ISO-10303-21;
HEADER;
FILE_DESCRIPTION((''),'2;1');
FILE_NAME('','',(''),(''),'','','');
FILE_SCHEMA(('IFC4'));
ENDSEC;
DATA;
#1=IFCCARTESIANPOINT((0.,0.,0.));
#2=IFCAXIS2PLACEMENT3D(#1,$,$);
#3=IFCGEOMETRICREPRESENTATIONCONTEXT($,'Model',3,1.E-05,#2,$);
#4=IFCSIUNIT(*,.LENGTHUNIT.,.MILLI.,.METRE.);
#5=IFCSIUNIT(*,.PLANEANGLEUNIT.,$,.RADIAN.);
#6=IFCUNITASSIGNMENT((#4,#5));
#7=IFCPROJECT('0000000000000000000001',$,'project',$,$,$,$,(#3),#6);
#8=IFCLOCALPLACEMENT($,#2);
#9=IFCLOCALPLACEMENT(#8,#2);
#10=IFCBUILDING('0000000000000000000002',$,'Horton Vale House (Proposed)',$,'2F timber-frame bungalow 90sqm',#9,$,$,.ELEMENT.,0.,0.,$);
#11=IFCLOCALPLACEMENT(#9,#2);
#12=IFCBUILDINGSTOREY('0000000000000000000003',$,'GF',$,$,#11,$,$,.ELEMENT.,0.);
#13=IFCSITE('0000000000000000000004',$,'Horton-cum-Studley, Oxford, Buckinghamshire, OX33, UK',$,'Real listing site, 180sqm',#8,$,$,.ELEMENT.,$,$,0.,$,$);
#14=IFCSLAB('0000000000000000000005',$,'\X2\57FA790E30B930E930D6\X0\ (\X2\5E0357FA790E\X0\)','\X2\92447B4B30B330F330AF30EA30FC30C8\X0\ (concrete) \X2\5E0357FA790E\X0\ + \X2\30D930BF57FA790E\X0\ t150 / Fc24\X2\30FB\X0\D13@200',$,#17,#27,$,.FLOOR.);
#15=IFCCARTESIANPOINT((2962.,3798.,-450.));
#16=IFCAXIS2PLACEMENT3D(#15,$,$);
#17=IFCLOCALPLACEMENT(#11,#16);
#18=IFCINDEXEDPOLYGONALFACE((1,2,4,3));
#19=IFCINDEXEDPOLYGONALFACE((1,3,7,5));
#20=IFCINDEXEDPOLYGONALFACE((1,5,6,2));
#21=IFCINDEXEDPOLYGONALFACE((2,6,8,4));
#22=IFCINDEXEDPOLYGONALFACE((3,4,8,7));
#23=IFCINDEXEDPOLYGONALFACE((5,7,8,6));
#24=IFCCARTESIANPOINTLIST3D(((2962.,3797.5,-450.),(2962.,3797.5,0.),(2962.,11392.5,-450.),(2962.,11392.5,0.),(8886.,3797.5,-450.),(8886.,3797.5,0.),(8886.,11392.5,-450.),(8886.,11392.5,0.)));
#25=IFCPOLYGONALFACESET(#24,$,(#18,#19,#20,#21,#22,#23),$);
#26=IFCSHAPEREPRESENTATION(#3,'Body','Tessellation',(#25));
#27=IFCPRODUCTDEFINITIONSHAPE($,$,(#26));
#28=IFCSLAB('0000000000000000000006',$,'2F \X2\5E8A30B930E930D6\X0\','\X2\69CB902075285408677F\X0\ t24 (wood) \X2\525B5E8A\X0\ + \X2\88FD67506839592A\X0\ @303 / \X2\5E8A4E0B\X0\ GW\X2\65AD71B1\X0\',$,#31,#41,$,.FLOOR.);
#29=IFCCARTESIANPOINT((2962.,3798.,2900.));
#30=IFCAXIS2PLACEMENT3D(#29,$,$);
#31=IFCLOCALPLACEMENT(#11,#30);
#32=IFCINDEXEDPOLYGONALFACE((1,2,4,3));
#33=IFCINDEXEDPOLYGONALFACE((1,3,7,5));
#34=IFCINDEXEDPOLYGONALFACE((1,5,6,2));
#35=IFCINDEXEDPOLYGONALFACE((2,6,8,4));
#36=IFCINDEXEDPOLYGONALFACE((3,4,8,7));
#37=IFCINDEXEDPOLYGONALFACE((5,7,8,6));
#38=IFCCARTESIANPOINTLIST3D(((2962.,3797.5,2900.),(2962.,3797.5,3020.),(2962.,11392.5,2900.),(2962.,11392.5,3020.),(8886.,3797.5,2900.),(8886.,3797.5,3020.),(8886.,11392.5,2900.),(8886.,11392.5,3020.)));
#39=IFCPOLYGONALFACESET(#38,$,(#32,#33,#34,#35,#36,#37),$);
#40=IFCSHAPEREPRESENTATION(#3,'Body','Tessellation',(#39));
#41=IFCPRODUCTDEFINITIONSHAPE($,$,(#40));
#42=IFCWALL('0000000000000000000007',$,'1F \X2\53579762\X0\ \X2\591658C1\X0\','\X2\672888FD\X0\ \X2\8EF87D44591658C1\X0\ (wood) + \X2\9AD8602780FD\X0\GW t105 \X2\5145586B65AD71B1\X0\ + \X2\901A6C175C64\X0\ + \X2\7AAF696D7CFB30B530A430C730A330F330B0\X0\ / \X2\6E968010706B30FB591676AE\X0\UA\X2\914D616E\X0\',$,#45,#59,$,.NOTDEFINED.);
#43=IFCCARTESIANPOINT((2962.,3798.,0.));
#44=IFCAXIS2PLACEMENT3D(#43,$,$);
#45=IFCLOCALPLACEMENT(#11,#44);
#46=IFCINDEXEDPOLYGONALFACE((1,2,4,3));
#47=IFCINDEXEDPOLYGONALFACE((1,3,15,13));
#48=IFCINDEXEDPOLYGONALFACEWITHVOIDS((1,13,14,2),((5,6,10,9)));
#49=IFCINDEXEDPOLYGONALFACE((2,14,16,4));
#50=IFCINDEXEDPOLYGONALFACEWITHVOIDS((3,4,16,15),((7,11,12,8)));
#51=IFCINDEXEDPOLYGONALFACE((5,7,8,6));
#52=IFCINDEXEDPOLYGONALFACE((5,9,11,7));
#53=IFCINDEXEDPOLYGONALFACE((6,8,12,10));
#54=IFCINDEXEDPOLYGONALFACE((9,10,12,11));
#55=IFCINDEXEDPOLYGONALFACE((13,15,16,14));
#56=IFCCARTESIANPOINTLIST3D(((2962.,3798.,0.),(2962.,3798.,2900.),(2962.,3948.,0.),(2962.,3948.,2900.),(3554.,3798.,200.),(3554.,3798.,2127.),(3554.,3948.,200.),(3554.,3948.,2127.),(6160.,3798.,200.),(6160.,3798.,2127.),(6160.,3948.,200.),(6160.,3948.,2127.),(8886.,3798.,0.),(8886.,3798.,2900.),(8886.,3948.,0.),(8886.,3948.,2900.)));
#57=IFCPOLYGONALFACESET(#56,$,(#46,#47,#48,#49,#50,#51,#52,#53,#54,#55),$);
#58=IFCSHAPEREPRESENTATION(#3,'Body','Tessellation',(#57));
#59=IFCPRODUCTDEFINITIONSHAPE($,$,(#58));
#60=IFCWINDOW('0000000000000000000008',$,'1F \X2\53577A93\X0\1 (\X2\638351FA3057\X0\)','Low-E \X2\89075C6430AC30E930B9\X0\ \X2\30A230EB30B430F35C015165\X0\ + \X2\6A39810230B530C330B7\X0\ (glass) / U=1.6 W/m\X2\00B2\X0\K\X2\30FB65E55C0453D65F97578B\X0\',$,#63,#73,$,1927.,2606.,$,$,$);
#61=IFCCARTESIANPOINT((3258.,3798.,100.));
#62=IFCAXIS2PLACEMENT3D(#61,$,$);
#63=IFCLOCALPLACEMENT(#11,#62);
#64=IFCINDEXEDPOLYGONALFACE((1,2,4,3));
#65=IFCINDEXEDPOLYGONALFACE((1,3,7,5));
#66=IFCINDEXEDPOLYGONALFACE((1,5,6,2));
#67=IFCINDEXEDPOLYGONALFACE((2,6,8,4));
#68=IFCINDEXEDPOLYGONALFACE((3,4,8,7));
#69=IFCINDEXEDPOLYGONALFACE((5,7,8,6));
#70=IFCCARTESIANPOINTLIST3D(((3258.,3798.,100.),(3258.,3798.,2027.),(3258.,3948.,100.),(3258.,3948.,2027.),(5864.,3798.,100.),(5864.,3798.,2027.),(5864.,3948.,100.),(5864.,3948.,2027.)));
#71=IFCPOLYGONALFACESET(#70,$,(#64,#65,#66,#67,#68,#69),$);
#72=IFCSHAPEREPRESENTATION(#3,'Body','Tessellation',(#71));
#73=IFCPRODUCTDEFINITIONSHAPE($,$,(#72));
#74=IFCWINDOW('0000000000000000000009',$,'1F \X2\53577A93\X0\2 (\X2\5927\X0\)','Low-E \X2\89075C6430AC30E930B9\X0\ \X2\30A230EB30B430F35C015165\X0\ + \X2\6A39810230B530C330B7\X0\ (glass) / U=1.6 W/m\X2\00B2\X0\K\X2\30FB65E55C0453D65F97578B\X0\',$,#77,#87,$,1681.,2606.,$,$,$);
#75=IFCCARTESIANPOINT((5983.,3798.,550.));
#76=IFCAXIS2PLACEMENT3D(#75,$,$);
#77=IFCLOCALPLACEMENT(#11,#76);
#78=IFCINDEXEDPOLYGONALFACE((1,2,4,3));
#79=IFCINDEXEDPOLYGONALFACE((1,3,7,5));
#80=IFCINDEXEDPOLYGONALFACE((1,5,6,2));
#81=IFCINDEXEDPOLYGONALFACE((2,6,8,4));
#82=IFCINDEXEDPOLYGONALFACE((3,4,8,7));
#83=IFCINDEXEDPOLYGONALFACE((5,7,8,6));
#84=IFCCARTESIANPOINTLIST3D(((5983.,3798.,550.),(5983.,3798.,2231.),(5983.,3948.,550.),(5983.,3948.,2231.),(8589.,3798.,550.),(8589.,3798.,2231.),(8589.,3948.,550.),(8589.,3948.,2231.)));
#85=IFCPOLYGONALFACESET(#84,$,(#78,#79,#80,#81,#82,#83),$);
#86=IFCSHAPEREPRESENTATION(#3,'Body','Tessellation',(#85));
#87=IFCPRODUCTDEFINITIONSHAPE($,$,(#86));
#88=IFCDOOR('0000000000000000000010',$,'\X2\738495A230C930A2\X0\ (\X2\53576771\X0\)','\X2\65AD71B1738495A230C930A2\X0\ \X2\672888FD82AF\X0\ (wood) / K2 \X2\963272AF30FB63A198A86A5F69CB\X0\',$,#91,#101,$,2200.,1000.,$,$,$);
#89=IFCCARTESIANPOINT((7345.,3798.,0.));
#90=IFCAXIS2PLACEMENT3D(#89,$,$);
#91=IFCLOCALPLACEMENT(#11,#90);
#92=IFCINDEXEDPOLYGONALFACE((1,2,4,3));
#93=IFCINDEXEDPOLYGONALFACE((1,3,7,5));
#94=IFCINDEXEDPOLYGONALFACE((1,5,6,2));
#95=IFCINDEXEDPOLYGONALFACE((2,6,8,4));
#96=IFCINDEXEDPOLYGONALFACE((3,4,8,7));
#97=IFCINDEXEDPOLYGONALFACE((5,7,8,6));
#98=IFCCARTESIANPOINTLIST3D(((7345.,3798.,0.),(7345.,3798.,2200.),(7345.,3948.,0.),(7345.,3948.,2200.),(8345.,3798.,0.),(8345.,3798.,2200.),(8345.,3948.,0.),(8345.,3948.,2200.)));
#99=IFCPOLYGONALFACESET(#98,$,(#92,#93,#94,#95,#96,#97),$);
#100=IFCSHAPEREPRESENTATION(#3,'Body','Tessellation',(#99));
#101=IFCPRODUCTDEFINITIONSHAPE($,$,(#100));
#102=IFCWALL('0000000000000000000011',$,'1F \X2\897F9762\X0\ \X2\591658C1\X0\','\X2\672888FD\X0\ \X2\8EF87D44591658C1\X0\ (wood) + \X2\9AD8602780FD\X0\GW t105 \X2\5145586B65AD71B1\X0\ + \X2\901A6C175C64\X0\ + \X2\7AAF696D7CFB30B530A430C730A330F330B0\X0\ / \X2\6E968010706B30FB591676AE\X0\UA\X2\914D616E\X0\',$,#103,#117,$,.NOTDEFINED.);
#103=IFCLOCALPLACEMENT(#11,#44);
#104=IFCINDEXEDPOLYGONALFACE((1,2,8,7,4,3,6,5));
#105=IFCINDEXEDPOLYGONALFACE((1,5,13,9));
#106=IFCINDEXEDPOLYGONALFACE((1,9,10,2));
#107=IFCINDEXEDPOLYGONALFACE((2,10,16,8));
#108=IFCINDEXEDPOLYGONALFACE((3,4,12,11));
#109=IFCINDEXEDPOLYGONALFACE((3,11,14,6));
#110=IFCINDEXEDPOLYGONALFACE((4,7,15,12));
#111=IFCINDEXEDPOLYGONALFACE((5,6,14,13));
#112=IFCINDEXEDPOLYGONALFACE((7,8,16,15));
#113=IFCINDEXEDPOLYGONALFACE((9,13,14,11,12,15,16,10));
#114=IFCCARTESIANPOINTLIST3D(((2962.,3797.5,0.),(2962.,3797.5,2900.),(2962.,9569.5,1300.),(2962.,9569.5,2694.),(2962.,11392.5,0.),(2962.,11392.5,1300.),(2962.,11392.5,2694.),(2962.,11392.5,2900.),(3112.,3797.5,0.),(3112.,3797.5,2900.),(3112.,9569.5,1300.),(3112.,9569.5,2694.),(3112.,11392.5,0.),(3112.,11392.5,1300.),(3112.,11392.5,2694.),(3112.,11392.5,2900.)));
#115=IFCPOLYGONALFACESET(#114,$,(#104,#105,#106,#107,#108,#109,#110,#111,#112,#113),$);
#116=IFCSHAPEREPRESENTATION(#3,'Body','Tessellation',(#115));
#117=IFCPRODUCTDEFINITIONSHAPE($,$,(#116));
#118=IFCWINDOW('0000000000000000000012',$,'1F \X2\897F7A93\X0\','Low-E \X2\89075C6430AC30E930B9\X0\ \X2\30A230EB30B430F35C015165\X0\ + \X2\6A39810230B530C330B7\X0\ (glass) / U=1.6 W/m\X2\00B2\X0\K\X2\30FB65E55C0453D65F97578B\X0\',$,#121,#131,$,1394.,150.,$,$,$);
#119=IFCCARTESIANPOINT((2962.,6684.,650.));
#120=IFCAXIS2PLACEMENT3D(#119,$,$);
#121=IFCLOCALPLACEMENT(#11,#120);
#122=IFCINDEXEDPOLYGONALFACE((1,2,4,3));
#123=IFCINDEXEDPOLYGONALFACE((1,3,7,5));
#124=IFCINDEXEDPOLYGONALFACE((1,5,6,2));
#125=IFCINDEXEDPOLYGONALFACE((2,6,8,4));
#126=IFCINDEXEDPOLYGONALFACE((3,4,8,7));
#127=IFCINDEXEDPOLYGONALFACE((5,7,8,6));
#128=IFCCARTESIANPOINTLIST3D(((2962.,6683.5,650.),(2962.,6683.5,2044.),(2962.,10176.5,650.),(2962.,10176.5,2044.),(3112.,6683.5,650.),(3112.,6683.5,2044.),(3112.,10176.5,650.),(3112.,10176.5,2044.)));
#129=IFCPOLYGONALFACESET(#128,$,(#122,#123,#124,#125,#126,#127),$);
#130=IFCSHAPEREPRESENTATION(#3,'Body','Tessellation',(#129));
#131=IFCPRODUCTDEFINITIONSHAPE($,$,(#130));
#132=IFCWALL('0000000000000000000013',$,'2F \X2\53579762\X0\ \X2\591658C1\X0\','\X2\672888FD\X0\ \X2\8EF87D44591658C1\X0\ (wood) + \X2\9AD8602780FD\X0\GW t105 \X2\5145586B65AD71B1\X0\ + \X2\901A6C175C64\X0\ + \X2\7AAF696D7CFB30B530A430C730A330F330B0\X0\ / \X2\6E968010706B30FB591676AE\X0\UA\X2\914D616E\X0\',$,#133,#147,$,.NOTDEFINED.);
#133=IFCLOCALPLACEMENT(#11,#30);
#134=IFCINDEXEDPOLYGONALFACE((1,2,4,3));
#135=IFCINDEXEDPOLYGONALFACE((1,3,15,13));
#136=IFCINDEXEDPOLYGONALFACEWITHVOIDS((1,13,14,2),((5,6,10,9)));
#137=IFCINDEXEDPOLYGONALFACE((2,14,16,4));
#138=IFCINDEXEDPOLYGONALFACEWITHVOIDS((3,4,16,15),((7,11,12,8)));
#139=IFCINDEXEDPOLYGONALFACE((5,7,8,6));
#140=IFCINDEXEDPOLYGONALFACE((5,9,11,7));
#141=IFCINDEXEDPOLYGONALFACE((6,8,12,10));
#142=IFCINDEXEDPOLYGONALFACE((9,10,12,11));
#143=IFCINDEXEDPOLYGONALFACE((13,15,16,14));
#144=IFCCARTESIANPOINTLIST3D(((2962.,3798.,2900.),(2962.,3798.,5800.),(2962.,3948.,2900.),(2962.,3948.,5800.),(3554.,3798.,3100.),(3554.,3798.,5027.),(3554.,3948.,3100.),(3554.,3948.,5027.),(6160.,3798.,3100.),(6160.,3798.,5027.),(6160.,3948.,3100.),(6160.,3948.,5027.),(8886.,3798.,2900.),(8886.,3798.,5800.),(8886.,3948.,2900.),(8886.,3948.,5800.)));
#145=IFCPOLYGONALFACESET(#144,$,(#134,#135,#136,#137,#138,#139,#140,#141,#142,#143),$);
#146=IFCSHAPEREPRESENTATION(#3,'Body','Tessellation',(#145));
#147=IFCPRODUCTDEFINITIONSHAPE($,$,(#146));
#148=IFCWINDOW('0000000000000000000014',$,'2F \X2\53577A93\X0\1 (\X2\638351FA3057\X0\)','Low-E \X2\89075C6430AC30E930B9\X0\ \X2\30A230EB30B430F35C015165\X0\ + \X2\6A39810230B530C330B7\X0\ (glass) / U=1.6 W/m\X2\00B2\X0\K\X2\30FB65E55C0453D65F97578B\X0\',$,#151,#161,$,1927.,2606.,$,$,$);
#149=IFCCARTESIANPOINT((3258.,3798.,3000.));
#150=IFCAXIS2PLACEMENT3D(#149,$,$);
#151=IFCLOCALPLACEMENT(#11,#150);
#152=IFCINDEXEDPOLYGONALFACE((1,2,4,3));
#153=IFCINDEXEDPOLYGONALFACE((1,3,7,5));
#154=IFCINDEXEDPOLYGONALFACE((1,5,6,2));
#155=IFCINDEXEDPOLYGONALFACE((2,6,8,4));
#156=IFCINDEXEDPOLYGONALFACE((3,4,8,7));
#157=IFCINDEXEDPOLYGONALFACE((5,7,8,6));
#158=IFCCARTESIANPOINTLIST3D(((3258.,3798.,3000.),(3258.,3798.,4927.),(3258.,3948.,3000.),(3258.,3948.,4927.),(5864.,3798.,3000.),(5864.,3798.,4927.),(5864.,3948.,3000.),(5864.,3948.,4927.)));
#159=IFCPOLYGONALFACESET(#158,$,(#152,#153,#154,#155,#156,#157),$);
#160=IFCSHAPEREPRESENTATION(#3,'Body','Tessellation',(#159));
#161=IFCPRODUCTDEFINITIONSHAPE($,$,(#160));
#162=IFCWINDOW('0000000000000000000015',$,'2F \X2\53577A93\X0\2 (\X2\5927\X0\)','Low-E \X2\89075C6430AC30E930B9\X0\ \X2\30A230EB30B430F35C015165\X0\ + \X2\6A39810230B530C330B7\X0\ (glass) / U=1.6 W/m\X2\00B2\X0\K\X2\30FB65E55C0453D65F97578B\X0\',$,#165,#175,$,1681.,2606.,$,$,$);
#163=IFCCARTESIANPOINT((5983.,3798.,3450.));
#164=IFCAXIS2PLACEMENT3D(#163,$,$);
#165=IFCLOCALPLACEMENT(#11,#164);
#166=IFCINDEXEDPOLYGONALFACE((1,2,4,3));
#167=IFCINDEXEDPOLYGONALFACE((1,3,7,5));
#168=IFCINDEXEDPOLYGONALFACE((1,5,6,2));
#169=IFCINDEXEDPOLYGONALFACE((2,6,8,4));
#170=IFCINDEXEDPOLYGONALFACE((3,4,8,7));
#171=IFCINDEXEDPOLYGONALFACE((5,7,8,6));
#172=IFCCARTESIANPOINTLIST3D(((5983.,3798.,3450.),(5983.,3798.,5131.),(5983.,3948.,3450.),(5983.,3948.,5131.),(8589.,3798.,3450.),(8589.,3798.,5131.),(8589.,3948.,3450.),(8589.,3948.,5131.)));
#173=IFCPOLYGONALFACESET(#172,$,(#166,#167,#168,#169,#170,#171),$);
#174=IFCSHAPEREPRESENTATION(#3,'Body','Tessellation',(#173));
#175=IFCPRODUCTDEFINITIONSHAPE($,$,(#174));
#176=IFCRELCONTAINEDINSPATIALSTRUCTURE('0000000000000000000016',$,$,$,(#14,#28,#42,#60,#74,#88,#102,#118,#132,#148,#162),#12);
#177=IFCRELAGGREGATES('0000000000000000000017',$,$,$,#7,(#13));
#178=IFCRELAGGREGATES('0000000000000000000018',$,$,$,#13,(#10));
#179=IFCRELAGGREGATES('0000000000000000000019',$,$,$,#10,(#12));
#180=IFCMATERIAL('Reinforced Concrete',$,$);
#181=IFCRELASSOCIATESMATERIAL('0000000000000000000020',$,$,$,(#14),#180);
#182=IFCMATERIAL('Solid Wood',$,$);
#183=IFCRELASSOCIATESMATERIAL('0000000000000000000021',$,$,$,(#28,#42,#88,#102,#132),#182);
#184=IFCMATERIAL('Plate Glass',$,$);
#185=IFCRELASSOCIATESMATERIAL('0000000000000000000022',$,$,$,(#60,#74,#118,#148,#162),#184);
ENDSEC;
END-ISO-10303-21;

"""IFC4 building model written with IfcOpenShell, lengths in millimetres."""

from ifc_helpers import new_model, si_unit, frame, frame_2d, origin, place, context, project, spatial, rectangle, extrude, material, element, fill, save


model = new_model("IFC4")

# Units and contexts
model_context = context("Model", 3, precision=1e-05, world=origin())
ifc_project = project(units=[si_unit("LENGTHUNIT", "METRE", prefix="MILLI"), si_unit("PLANEANGLEUNIT", "RADIAN")], contexts=[model_context])

# Site, building, storey
site_placement = place(None, origin())
site = spatial("IfcSite", under=ifc_project, at=site_placement, Name="Horton-cum-Studley, Oxford, Buckinghamshire, OX33, UK", ObjectType="Real listing site, 180sqm", CompositionType="ELEMENT", RefElevation=0.0)
building_placement = place(site_placement, origin())
building = spatial("IfcBuilding", under=site, at=building_placement, Name="Horton Vale House (Proposed)", ObjectType="2F timber-frame bungalow 90sqm", CompositionType="ELEMENT", ElevationOfRefHeight=0.0, ElevationOfTerrain=0.0)
storey_placement = place(building_placement, origin())
storey = spatial("IfcBuildingStorey", under=building, at=storey_placement, Name="GF", CompositionType="ELEMENT", Elevation=0.0)

# Slabs
ifc_material_1 = material(Name="Reinforced Concrete")
slab_1_placement = place(storey_placement, frame((2962.0, 3798.0, -450.0)))
element("IfcSlab", 1, at=slab_1_placement, inside=storey, material=ifc_material_1, Name="基礎スラブ (布基礎)", Description="鉄筋コンクリート (concrete) 布基礎 + ベタ基礎 t150 / Fc24・D13@200", PredefinedType="FLOOR", context=model_context, shape_type="SweptSolid", body=[
    extrude(rectangle(XDim=5924.0, YDim=7595.0, at=frame_2d((2962.0, 3797.0))), frame((2962.0, 3798.0, -450.0)), (0.0, 0.0, 1.0), 450.0),
])
ifc_material_2 = material(Name="Solid Wood")
slab_2_placement = place(storey_placement, frame((2962.0, 3798.0, 2900.0)))
element("IfcSlab", 2, at=slab_2_placement, inside=storey, material=ifc_material_2, Name="2F 床スラブ", Description="構造用合板 t24 (wood) 剛床 + 製材根太 @303 / 床下 GW断熱", PredefinedType="FLOOR", context=model_context, shape_type="SweptSolid", body=[
    extrude(rectangle(XDim=5924.0, YDim=7595.0, at=frame_2d((2962.0, 3797.0))), frame((2962.0, 3798.0, 2900.0)), (0.0, 0.0, 1.0), 120.0),
])

# Wall, openings, windows, door
wall_1_placement = place(storey_placement, frame((2962.0, 3798.0, 0.0)))
wall_1 = element("IfcWall", 3, at=wall_1_placement, inside=storey, material=ifc_material_2, Name="1F 南面 外壁", Description="木製 軸組外壁 (wood) + 高性能GW t105 充填断熱 + 通気層 + 窯業系サイディング / 準耐火・外皮UA配慮", PredefinedType="NOTDEFINED", context=model_context, shape_type="SweptSolid", body=[
    extrude(rectangle(XDim=5924.0, YDim=150.0, at=frame_2d((2962.0, 75.0))), frame((2962.0, 3798.0, 0.0)), (0.0, 0.0, 1.0), 2900.0),
])
opening_1_placement = place(storey_placement, frame((3258.0, 3798.0, 100.0)))
opening_1 = element("IfcOpeningElement", 4, at=opening_1_placement, cuts=wall_1, PredefinedType="NOTDEFINED", context=model_context, shape_type="SweptSolid", body=[
    extrude(rectangle(XDim=2606.0, YDim=150.0, at=frame_2d((1303.0, 75.0))), frame((3258.0, 3798.0, 100.0)), (0.0, 0.0, 1.0), 1927.0),
])
opening_2_placement = place(storey_placement, frame((5983.0, 3798.0, 550.0)))
opening_2 = element("IfcOpeningElement", 5, at=opening_2_placement, cuts=wall_1, PredefinedType="NOTDEFINED", context=model_context, shape_type="SweptSolid", body=[
    extrude(rectangle(XDim=2606.0, YDim=150.0, at=frame_2d((1303.0, 75.0))), frame((5983.0, 3798.0, 550.0)), (0.0, 0.0, 1.0), 1681.0),
])
opening_3_placement = place(storey_placement, frame((7345.0, 3798.0, 0.0)))
opening_3 = element("IfcOpeningElement", 6, at=opening_3_placement, cuts=wall_1, PredefinedType="NOTDEFINED", context=model_context, shape_type="SweptSolid", body=[
    extrude(rectangle(XDim=1000.0, YDim=150.0, at=frame_2d((500.0, 75.0))), frame((7345.0, 3798.0, 0.0)), (0.0, 0.0, 1.0), 2200.0),
])
ifc_material_3 = material(Name="Plate Glass")
window_1_placement = place(storey_placement, frame((3258.0, 3798.0, 100.0)))
window_1 = element("IfcWindow", 7, at=window_1_placement, inside=storey, material=ifc_material_3, Name="1F 南窓1 (掃出し)", Description="Low-E 複層ガラス アルゴン封入 + 樹脂サッシ (glass) / U=1.6 W/m²K・日射取得型", OverallHeight=1927.0, OverallWidth=2606.0, context=model_context, shape_type="SweptSolid", body=[
    extrude(rectangle(XDim=2606.0, YDim=150.0, at=frame_2d((1303.0, 75.0))), frame((3258.0, 3798.0, 100.0)), (0.0, 0.0, 1.0), 1927.0),
])
fill(opening_1, window_1)
window_2_placement = place(storey_placement, frame((5983.0, 3798.0, 550.0)))
window_2 = element("IfcWindow", 8, at=window_2_placement, inside=storey, material=ifc_material_3, Name="1F 南窓2 (大)", Description="Low-E 複層ガラス アルゴン封入 + 樹脂サッシ (glass) / U=1.6 W/m²K・日射取得型", OverallHeight=1681.0, OverallWidth=2606.0, context=model_context, shape_type="SweptSolid", body=[
    extrude(rectangle(XDim=2606.0, YDim=150.0, at=frame_2d((1303.0, 75.0))), frame((5983.0, 3798.0, 550.0)), (0.0, 0.0, 1.0), 1681.0),
])
fill(opening_2, window_2)
door_placement = place(storey_placement, frame((7345.0, 3798.0, 0.0)))
door = element("IfcDoor", 9, at=door_placement, inside=storey, material=ifc_material_2, Name="玄関ドア (南東)", Description="断熱玄関ドア 木製芯 (wood) / K2 防犯・採風機構", OverallHeight=2200.0, OverallWidth=1000.0, context=model_context, shape_type="SweptSolid", body=[
    extrude(rectangle(XDim=1000.0, YDim=150.0, at=frame_2d((500.0, 75.0))), frame((7345.0, 3798.0, 0.0)), (0.0, 0.0, 1.0), 2200.0),
])
fill(opening_3, door)

# Wall, opening, window
wall_2_placement = place(storey_placement, frame((2962.0, 3798.0, 0.0)))
wall_2 = element("IfcWall", 10, at=wall_2_placement, inside=storey, material=ifc_material_2, Name="1F 西面 外壁", Description="木製 軸組外壁 (wood) + 高性能GW t105 充填断熱 + 通気層 + 窯業系サイディング / 準耐火・外皮UA配慮", PredefinedType="NOTDEFINED", context=model_context, shape_type="SweptSolid", body=[
    extrude(rectangle(XDim=150.0, YDim=7595.0, at=frame_2d((75.0, 3797.0))), frame((2962.0, 3798.0, 0.0)), (0.0, 0.0, 1.0), 2900.0),
])
opening_4_placement = place(storey_placement, frame((2962.0, 6684.0, 650.0)))
opening_4 = element("IfcOpeningElement", 11, at=opening_4_placement, cuts=wall_2, PredefinedType="NOTDEFINED", context=model_context, shape_type="SweptSolid", body=[
    extrude(rectangle(XDim=150.0, YDim=3493.0, at=frame_2d((75.0, 1746.0))), frame((2962.0, 6684.0, 650.0)), (0.0, 0.0, 1.0), 1394.0),
])
window_3_placement = place(storey_placement, frame((2962.0, 6684.0, 650.0)))
window_3 = element("IfcWindow", 12, at=window_3_placement, inside=storey, material=ifc_material_3, Name="1F 西窓", Description="Low-E 複層ガラス アルゴン封入 + 樹脂サッシ (glass) / U=1.6 W/m²K・日射取得型", OverallHeight=1394.0, OverallWidth=150.0, context=model_context, shape_type="SweptSolid", body=[
    extrude(rectangle(XDim=150.0, YDim=3493.0, at=frame_2d((75.0, 1746.0))), frame((2962.0, 6684.0, 650.0)), (0.0, 0.0, 1.0), 1394.0),
])
fill(opening_4, window_3)

# Wall, openings, windows
wall_3_placement = place(storey_placement, frame((2962.0, 3798.0, 2900.0)))
wall_3 = element("IfcWall", 13, at=wall_3_placement, inside=storey, material=ifc_material_2, Name="2F 南面 外壁", Description="木製 軸組外壁 (wood) + 高性能GW t105 充填断熱 + 通気層 + 窯業系サイディング / 準耐火・外皮UA配慮", PredefinedType="NOTDEFINED", context=model_context, shape_type="SweptSolid", body=[
    extrude(rectangle(XDim=5924.0, YDim=150.0, at=frame_2d((2962.0, 75.0))), frame((2962.0, 3798.0, 2900.0)), (0.0, 0.0, 1.0), 2900.0),
])
opening_5_placement = place(storey_placement, frame((3258.0, 3798.0, 3000.0)))
opening_5 = element("IfcOpeningElement", 14, at=opening_5_placement, cuts=wall_3, PredefinedType="NOTDEFINED", context=model_context, shape_type="SweptSolid", body=[
    extrude(rectangle(XDim=2606.0, YDim=150.0, at=frame_2d((1303.0, 75.0))), frame((3258.0, 3798.0, 3000.0)), (0.0, 0.0, 1.0), 1927.0),
])
opening_6_placement = place(storey_placement, frame((5983.0, 3798.0, 3450.0)))
opening_6 = element("IfcOpeningElement", 15, at=opening_6_placement, cuts=wall_3, PredefinedType="NOTDEFINED", context=model_context, shape_type="SweptSolid", body=[
    extrude(rectangle(XDim=2606.0, YDim=150.0, at=frame_2d((1303.0, 75.0))), frame((5983.0, 3798.0, 3450.0)), (0.0, 0.0, 1.0), 1681.0),
])
window_4_placement = place(storey_placement, frame((3258.0, 3798.0, 3000.0)))
window_4 = element("IfcWindow", 16, at=window_4_placement, inside=storey, material=ifc_material_3, Name="2F 南窓1 (掃出し)", Description="Low-E 複層ガラス アルゴン封入 + 樹脂サッシ (glass) / U=1.6 W/m²K・日射取得型", OverallHeight=1927.0, OverallWidth=2606.0, context=model_context, shape_type="SweptSolid", body=[
    extrude(rectangle(XDim=2606.0, YDim=150.0, at=frame_2d((1303.0, 75.0))), frame((3258.0, 3798.0, 3000.0)), (0.0, 0.0, 1.0), 1927.0),
])
fill(opening_5, window_4)
window_5_placement = place(storey_placement, frame((5983.0, 3798.0, 3450.0)))
window_5 = element("IfcWindow", 17, at=window_5_placement, inside=storey, material=ifc_material_3, Name="2F 南窓2 (大)", Description="Low-E 複層ガラス アルゴン封入 + 樹脂サッシ (glass) / U=1.6 W/m²K・日射取得型", OverallHeight=1681.0, OverallWidth=2606.0, context=model_context, shape_type="SweptSolid", body=[
    extrude(rectangle(XDim=2606.0, YDim=150.0, at=frame_2d((1303.0, 75.0))), frame((5983.0, 3798.0, 3450.0)), (0.0, 0.0, 1.0), 1681.0),
])
fill(opening_6, window_5)

save(model, "model.ifc")
